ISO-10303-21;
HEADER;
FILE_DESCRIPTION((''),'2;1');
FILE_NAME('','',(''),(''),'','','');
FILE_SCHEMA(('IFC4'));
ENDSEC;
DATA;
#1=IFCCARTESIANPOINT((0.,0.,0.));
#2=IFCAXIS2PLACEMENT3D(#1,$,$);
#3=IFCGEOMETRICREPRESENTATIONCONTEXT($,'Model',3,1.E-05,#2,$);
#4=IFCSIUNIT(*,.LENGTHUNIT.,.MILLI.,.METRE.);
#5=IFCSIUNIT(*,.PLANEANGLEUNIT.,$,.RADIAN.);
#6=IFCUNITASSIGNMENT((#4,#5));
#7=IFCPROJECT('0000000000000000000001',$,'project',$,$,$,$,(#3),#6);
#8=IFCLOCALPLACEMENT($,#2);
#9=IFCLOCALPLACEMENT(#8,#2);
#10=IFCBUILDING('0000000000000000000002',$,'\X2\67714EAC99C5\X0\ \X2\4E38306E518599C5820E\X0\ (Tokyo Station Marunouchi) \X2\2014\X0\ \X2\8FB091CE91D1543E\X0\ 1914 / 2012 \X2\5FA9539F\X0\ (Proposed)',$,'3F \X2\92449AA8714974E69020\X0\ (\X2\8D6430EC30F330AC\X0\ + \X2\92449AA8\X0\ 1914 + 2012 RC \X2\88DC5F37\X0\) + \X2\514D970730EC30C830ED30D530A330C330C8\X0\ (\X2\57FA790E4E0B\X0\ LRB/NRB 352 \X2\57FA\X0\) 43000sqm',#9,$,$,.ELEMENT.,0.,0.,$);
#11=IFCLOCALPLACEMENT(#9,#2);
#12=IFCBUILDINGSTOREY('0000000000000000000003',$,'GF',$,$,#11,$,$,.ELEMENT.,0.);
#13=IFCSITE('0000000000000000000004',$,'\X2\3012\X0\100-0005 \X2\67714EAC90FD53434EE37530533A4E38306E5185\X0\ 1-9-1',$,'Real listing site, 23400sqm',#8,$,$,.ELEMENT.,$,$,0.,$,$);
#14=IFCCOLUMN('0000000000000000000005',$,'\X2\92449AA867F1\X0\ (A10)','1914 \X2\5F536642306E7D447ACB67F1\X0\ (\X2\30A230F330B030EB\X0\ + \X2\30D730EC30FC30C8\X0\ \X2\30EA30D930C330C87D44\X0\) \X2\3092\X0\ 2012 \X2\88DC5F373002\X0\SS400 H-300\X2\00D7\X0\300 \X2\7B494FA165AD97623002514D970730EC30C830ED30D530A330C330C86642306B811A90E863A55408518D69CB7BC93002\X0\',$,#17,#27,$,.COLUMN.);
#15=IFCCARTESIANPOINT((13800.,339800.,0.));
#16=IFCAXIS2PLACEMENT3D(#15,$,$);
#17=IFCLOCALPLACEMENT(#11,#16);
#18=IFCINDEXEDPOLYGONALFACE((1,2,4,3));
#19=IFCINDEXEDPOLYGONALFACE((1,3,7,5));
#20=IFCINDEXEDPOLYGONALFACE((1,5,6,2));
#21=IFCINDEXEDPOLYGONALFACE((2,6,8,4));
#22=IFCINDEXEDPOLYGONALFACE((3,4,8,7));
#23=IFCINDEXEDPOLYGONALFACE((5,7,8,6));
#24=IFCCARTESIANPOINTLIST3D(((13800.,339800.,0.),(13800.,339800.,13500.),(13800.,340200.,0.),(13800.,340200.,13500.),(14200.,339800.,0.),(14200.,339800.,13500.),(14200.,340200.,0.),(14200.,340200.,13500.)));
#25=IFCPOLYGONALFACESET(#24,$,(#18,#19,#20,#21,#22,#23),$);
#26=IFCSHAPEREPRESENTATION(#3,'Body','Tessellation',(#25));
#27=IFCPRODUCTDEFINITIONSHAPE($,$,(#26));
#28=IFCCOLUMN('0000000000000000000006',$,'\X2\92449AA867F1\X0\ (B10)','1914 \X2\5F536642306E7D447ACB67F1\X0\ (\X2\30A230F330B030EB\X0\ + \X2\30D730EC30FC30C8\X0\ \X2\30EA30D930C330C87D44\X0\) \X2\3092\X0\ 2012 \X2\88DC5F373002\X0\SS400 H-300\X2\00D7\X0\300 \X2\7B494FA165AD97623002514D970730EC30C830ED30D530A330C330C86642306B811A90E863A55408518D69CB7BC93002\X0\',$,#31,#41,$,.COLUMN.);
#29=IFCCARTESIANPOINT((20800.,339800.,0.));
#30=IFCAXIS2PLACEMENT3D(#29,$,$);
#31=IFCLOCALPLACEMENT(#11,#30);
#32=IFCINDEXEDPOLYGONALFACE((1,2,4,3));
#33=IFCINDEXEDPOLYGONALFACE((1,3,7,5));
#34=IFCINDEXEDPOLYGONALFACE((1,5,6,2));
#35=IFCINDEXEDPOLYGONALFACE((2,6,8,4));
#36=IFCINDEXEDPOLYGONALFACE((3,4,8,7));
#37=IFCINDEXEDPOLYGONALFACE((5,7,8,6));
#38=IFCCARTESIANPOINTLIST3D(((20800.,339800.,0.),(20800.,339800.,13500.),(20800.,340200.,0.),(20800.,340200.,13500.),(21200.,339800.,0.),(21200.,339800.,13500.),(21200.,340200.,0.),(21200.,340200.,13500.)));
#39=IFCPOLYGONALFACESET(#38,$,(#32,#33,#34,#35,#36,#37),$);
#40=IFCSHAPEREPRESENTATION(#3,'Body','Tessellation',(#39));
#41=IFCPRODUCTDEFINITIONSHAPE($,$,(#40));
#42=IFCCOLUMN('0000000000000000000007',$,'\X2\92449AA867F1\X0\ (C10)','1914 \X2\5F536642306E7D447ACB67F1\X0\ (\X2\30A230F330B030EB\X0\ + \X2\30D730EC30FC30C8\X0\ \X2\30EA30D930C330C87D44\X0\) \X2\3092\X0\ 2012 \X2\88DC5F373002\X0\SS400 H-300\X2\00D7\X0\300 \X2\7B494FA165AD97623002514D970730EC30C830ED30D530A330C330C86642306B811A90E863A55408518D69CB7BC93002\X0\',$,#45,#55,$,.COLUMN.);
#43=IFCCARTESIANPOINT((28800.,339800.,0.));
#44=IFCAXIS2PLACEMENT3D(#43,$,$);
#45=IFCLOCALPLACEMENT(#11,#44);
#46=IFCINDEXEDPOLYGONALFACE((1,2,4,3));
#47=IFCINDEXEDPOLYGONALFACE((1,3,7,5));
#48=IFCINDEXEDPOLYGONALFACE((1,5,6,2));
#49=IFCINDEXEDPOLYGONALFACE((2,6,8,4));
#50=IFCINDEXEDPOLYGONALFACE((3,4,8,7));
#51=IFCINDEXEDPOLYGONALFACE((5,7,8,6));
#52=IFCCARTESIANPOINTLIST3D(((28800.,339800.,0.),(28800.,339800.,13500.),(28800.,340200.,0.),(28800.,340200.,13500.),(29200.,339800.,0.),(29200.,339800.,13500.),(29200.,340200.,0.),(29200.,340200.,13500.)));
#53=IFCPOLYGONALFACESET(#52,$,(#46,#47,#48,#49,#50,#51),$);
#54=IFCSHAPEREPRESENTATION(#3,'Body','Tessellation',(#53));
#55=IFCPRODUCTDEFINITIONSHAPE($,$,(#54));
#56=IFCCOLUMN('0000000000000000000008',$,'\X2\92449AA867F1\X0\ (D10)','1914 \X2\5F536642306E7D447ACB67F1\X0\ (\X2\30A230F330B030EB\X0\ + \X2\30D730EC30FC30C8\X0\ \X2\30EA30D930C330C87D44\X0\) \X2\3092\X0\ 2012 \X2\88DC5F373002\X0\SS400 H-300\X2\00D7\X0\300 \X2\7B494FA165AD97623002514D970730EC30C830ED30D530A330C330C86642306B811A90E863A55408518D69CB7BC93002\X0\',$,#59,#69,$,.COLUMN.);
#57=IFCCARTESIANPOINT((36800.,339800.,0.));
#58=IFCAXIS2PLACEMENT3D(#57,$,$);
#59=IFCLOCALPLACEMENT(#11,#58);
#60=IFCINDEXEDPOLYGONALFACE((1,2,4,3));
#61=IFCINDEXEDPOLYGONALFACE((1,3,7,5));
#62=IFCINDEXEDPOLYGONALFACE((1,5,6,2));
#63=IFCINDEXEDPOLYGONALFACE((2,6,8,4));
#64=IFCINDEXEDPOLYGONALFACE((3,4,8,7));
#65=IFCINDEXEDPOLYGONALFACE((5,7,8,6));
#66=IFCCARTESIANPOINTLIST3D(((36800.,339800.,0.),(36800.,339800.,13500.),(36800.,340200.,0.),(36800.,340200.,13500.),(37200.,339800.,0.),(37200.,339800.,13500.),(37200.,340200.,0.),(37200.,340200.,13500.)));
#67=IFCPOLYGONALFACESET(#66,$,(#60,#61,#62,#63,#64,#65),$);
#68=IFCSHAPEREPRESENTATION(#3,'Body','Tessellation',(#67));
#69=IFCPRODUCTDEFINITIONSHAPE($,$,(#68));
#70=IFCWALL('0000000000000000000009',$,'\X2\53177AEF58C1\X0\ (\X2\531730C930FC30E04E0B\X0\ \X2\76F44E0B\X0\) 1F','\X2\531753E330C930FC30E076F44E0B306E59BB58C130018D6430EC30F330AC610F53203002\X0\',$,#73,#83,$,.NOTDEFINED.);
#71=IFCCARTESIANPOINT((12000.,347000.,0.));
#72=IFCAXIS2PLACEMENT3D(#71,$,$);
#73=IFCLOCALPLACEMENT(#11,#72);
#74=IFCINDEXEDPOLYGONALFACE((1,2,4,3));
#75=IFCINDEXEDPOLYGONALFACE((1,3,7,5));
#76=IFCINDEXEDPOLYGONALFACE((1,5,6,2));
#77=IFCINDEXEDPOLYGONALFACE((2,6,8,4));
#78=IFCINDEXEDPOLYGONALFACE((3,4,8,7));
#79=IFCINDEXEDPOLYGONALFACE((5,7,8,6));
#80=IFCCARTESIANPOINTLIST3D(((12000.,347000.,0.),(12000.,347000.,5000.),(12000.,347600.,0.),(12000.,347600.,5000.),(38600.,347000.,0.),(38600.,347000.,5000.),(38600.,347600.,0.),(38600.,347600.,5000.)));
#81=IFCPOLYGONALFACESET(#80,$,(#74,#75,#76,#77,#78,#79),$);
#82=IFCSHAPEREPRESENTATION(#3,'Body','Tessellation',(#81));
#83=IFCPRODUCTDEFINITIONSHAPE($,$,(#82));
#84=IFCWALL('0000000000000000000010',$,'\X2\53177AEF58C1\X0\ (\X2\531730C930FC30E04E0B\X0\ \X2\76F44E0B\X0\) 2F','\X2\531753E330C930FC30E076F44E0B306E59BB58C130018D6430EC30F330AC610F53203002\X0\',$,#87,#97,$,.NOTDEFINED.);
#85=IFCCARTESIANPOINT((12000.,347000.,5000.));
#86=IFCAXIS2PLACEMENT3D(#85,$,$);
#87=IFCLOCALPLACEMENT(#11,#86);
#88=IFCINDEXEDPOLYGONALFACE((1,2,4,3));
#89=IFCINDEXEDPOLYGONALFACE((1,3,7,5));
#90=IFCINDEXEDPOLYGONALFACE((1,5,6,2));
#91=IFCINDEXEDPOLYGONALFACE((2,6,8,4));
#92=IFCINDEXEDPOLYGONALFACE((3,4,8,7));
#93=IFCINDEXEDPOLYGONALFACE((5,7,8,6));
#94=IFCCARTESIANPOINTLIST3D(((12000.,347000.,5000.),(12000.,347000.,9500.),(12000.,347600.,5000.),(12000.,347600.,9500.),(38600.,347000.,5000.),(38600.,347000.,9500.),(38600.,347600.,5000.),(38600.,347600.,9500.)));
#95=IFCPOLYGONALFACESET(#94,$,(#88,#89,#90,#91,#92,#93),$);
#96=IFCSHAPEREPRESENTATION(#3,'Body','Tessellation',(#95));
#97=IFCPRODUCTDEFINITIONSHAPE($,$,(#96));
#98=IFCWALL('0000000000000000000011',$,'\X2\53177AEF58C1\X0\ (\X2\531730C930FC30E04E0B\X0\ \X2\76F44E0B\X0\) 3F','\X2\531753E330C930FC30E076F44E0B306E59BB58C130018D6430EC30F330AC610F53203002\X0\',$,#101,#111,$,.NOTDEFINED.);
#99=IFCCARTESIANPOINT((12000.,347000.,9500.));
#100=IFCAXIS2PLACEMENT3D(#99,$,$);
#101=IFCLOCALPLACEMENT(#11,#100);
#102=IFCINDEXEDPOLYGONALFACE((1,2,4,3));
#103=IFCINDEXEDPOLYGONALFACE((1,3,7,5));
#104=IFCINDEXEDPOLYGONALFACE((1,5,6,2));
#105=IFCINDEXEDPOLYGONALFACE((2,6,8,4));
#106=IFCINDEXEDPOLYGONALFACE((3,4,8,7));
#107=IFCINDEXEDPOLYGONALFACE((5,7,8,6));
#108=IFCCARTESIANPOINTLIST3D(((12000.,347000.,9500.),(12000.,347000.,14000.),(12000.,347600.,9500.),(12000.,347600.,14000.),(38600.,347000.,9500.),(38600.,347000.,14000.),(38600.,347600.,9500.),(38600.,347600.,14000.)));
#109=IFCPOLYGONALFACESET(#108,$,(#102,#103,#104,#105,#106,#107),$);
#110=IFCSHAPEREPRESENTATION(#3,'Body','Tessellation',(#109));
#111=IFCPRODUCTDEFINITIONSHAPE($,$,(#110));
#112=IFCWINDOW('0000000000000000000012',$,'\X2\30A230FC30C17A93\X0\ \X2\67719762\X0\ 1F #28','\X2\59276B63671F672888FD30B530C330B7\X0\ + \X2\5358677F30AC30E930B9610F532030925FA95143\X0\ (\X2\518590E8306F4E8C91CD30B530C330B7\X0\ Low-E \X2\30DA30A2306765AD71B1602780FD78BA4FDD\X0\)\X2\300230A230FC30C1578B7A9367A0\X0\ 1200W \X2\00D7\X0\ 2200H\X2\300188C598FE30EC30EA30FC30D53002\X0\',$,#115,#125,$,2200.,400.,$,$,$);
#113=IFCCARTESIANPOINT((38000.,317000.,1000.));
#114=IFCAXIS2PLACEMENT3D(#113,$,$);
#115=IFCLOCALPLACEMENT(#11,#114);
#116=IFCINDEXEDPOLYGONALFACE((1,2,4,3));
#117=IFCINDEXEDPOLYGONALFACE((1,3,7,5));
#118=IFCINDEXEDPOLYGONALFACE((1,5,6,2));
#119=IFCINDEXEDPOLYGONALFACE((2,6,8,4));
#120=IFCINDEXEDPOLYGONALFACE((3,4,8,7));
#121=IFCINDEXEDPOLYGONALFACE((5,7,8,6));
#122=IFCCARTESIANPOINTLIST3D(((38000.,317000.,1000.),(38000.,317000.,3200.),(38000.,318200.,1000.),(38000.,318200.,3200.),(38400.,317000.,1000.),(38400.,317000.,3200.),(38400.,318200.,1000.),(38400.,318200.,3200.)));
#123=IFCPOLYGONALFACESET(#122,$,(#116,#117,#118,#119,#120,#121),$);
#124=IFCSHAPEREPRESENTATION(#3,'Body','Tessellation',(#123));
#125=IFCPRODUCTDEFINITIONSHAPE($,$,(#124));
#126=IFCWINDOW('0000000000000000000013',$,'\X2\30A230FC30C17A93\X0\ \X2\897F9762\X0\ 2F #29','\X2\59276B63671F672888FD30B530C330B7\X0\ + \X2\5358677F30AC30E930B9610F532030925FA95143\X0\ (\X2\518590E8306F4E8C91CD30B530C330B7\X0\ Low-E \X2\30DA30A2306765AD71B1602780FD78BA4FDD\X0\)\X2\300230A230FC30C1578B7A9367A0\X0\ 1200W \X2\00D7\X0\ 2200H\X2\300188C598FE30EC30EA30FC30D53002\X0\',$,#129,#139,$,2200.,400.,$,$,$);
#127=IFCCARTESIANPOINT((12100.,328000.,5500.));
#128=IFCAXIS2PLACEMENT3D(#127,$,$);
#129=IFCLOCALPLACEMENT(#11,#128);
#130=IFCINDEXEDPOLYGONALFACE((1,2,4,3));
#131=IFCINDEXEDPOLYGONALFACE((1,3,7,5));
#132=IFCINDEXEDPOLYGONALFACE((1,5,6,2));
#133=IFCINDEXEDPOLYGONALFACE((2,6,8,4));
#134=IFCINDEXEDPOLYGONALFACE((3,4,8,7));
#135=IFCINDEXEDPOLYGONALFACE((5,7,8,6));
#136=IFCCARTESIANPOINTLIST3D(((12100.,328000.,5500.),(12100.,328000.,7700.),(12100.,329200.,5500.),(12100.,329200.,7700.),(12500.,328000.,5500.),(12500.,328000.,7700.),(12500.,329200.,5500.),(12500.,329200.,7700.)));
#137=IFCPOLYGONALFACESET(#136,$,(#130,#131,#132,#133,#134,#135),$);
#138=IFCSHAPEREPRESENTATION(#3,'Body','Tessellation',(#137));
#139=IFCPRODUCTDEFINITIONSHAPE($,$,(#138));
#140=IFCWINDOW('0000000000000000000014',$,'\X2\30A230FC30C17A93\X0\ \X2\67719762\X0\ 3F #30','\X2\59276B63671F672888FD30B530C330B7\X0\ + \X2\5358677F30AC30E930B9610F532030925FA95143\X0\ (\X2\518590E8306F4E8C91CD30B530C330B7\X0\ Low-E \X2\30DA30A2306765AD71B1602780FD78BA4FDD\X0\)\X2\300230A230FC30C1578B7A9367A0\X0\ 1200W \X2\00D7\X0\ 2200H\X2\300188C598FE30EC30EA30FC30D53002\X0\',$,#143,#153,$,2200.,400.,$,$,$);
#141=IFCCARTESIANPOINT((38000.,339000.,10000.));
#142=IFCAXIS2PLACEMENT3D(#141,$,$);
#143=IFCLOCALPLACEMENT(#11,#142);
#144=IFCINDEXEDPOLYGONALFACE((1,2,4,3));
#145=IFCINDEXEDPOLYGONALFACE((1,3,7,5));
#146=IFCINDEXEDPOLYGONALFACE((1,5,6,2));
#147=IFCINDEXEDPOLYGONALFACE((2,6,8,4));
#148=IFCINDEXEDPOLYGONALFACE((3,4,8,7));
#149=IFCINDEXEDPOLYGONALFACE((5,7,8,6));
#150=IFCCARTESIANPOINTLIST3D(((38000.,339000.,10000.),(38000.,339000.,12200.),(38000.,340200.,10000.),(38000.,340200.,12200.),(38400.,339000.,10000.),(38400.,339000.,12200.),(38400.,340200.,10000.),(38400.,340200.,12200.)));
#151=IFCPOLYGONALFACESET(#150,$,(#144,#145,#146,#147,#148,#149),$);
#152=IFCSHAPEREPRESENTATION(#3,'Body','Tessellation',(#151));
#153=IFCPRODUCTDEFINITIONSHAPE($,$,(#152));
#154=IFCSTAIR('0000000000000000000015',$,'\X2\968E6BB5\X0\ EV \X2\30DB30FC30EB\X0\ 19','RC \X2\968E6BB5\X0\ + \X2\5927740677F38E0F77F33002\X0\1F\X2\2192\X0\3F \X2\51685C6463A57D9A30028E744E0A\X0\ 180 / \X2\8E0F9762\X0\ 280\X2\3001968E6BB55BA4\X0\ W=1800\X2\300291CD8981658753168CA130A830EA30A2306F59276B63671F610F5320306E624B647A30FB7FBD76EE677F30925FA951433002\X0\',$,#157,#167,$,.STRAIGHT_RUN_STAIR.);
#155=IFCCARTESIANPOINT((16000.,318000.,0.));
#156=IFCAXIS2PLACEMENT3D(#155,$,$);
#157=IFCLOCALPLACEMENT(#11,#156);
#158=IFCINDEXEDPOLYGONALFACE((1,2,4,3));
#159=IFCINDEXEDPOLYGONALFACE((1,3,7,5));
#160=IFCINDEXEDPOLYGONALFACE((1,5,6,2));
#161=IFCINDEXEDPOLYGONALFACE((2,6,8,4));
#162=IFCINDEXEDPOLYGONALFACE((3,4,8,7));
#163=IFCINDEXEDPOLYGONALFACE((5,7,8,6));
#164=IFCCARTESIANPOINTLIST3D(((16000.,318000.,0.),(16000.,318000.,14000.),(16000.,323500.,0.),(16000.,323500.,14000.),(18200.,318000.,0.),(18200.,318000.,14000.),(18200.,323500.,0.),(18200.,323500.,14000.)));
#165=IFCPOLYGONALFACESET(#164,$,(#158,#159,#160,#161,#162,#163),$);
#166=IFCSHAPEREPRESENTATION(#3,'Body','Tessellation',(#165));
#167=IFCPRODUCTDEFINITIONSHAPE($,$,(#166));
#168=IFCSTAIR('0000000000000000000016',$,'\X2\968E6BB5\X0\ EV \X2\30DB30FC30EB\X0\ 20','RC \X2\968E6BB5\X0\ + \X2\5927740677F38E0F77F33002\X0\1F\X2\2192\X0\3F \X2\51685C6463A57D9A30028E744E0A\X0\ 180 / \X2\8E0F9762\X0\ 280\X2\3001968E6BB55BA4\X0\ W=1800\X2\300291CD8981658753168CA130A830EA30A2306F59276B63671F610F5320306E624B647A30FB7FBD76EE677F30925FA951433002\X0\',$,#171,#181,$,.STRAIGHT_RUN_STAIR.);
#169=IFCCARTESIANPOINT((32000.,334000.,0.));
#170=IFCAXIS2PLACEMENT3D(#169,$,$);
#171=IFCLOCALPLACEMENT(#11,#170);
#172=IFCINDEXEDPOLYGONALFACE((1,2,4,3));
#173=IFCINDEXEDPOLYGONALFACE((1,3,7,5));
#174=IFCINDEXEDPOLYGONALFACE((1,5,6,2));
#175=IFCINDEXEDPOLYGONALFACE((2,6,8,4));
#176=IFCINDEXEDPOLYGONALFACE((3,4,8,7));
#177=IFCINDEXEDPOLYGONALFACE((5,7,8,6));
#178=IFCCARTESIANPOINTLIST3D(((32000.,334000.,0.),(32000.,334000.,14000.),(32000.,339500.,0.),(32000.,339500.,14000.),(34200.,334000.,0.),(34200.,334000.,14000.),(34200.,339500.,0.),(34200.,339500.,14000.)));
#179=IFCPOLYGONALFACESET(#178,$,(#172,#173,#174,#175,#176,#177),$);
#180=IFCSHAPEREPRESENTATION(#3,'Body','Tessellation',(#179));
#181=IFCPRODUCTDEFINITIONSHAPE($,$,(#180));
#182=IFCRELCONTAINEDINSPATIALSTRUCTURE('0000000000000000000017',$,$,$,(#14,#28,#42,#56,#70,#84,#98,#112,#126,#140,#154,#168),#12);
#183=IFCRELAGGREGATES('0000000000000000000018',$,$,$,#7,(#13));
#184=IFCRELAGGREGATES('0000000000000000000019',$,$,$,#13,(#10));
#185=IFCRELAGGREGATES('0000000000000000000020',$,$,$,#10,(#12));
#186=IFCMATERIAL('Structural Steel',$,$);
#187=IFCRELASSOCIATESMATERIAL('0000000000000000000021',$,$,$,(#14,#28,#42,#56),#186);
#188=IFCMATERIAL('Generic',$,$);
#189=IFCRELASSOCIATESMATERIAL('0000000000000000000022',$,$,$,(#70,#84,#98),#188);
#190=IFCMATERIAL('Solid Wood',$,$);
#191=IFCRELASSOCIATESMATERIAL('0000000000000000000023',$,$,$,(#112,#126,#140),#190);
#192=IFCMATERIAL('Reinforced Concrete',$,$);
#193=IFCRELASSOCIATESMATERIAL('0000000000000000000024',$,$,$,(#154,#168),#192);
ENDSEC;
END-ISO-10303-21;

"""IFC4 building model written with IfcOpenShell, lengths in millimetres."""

from ifc_helpers import new_model, si_unit, frame, frame_2d, origin, place, context, project, spatial, rectangle, extrude, material, element, save


model = new_model("IFC4")

# Units and contexts
model_context = context("Model", 3, precision=1e-05, world=origin())
ifc_project = project(units=[si_unit("LENGTHUNIT", "METRE", prefix="MILLI"), si_unit("PLANEANGLEUNIT", "RADIAN")], contexts=[model_context])

# Site, building, storey
site_placement = place(None, origin())
site = spatial("IfcSite", under=ifc_project, at=site_placement, Name="〒100-0005 東京都千代田区丸の内 1-9-1", ObjectType="Real listing site, 23400sqm", CompositionType="ELEMENT", RefElevation=0.0)
building_placement = place(site_placement, origin())
building = spatial("IfcBuilding", under=site, at=building_placement, Name="東京駅 丸の内駅舎 (Tokyo Station Marunouchi) — 辰野金吾 1914 / 2012 復原 (Proposed)", ObjectType="3F 鉄骨煉瓦造 (赤レンガ + 鉄骨 1914 + 2012 RC 補強) + 免震レトロフィット (基礎下 LRB/NRB 352 基) 43000sqm", CompositionType="ELEMENT", ElevationOfRefHeight=0.0, ElevationOfTerrain=0.0)
storey_placement = place(building_placement, origin())
storey = spatial("IfcBuildingStorey", under=building, at=storey_placement, Name="GF", CompositionType="ELEMENT", Elevation=0.0)

# Columns
ifc_material_1 = material(Name="Structural Steel")
column_1_placement = place(storey_placement, frame((13800.0, 339800.0, 0.0)))
element("IfcColumn", 1, at=column_1_placement, inside=storey, material=ifc_material_1, Name="鉄骨柱 (A10)", Description="1914 当時の組立柱 (アングル + プレート リベット組) を 2012 補強。SS400 H-300×300 等価断面。免震レトロフィット時に脚部接合再構築。", PredefinedType="COLUMN", context=model_context, shape_type="SweptSolid", body=[
    extrude(rectangle(XDim=400.0, YDim=400.0, at=frame_2d((200.0, 200.0))), frame((13800.0, 339800.0, 0.0)), (0.0, 0.0, 1.0), 13500.0),
])
column_2_placement = place(storey_placement, frame((20800.0, 339800.0, 0.0)))
element("IfcColumn", 2, at=column_2_placement, inside=storey, material=ifc_material_1, Name="鉄骨柱 (B10)", Description="1914 当時の組立柱 (アングル + プレート リベット組) を 2012 補強。SS400 H-300×300 等価断面。免震レトロフィット時に脚部接合再構築。", PredefinedType="COLUMN", context=model_context, shape_type="SweptSolid", body=[
    extrude(rectangle(XDim=400.0, YDim=400.0, at=frame_2d((200.0, 200.0))), frame((20800.0, 339800.0, 0.0)), (0.0, 0.0, 1.0), 13500.0),
])
column_3_placement = place(storey_placement, frame((28800.0, 339800.0, 0.0)))
element("IfcColumn", 3, at=column_3_placement, inside=storey, material=ifc_material_1, Name="鉄骨柱 (C10)", Description="1914 当時の組立柱 (アングル + プレート リベット組) を 2012 補強。SS400 H-300×300 等価断面。免震レトロフィット時に脚部接合再構築。", PredefinedType="COLUMN", context=model_context, shape_type="SweptSolid", body=[
    extrude(rectangle(XDim=400.0, YDim=400.0, at=frame_2d((200.0, 200.0))), frame((28800.0, 339800.0, 0.0)), (0.0, 0.0, 1.0), 13500.0),
])
column_4_placement = place(storey_placement, frame((36800.0, 339800.0, 0.0)))
element("IfcColumn", 4, at=column_4_placement, inside=storey, material=ifc_material_1, Name="鉄骨柱 (D10)", Description="1914 当時の組立柱 (アングル + プレート リベット組) を 2012 補強。SS400 H-300×300 等価断面。免震レトロフィット時に脚部接合再構築。", PredefinedType="COLUMN", context=model_context, shape_type="SweptSolid", body=[
    extrude(rectangle(XDim=400.0, YDim=400.0, at=frame_2d((200.0, 200.0))), frame((36800.0, 339800.0, 0.0)), (0.0, 0.0, 1.0), 13500.0),
])

# Walls
ifc_material_2 = material(Name="Generic")
wall_1_placement = place(storey_placement, frame((12000.0, 347000.0, 0.0)))
element("IfcWall", 5, at=wall_1_placement, inside=storey, material=ifc_material_2, Name="北端壁 (北ドーム下 直下) 1F", Description="北口ドーム直下の妻壁、赤レンガ意匠。", PredefinedType="NOTDEFINED", context=model_context, shape_type="SweptSolid", body=[
    extrude(rectangle(XDim=26600.0, YDim=600.0, at=frame_2d((13300.0, 300.0))), frame((12000.0, 347000.0, 0.0)), (0.0, 0.0, 1.0), 5000.0),
])
wall_2_placement = place(storey_placement, frame((12000.0, 347000.0, 5000.0)))
element("IfcWall", 6, at=wall_2_placement, inside=storey, material=ifc_material_2, Name="北端壁 (北ドーム下 直下) 2F", Description="北口ドーム直下の妻壁、赤レンガ意匠。", PredefinedType="NOTDEFINED", context=model_context, shape_type="SweptSolid", body=[
    extrude(rectangle(XDim=26600.0, YDim=600.0, at=frame_2d((13300.0, 300.0))), frame((12000.0, 347000.0, 5000.0)), (0.0, 0.0, 1.0), 4500.0),
])
wall_3_placement = place(storey_placement, frame((12000.0, 347000.0, 9500.0)))
element("IfcWall", 7, at=wall_3_placement, inside=storey, material=ifc_material_2, Name="北端壁 (北ドーム下 直下) 3F", Description="北口ドーム直下の妻壁、赤レンガ意匠。", PredefinedType="NOTDEFINED", context=model_context, shape_type="SweptSolid", body=[
    extrude(rectangle(XDim=26600.0, YDim=600.0, at=frame_2d((13300.0, 300.0))), frame((12000.0, 347000.0, 9500.0)), (0.0, 0.0, 1.0), 4500.0),
])

# Windows
ifc_material_3 = material(Name="Solid Wood")
window_1_placement = place(storey_placement, frame((38000.0, 317000.0, 1000.0)))
element("IfcWindow", 8, at=window_1_placement, inside=storey, material=ifc_material_3, Name="アーチ窓 東面 1F #28", Description="大正期木製サッシ + 単板ガラス意匠を復元 (内部は二重サッシ Low-E ペアで断熱性能確保)。アーチ型窓枠 1200W × 2200H、装飾レリーフ。", OverallHeight=2200.0, OverallWidth=400.0, context=model_context, shape_type="SweptSolid", body=[
    extrude(rectangle(XDim=400.0, YDim=1200.0, at=frame_2d((200.0, 600.0))), frame((38000.0, 317000.0, 1000.0)), (0.0, 0.0, 1.0), 2200.0),
])
window_2_placement = place(storey_placement, frame((12100.0, 328000.0, 5500.0)))
element("IfcWindow", 9, at=window_2_placement, inside=storey, material=ifc_material_3, Name="アーチ窓 西面 2F #29", Description="大正期木製サッシ + 単板ガラス意匠を復元 (内部は二重サッシ Low-E ペアで断熱性能確保)。アーチ型窓枠 1200W × 2200H、装飾レリーフ。", OverallHeight=2200.0, OverallWidth=400.0, context=model_context, shape_type="SweptSolid", body=[
    extrude(rectangle(XDim=400.0, YDim=1200.0, at=frame_2d((200.0, 600.0))), frame((12100.0, 328000.0, 5500.0)), (0.0, 0.0, 1.0), 2200.0),
])
window_3_placement = place(storey_placement, frame((38000.0, 339000.0, 10000.0)))
element("IfcWindow", 10, at=window_3_placement, inside=storey, material=ifc_material_3, Name="アーチ窓 東面 3F #30", Description="大正期木製サッシ + 単板ガラス意匠を復元 (内部は二重サッシ Low-E ペアで断熱性能確保)。アーチ型窓枠 1200W × 2200H、装飾レリーフ。", OverallHeight=2200.0, OverallWidth=400.0, context=model_context, shape_type="SweptSolid", body=[
    extrude(rectangle(XDim=400.0, YDim=1200.0, at=frame_2d((200.0, 600.0))), frame((38000.0, 339000.0, 10000.0)), (0.0, 0.0, 1.0), 2200.0),
])

# Stairs
ifc_material_4 = material(Name="Reinforced Concrete")
stair_1_placement = place(storey_placement, frame((16000.0, 318000.0, 0.0)))
element("IfcStair", 11, at=stair_1_placement, inside=storey, material=ifc_material_4, Name="階段 EV ホール 19", Description="RC 階段 + 大理石踏石。1F→3F 全層接続。蹴上 180 / 踏面 280、階段室 W=1800。重要文化財エリアは大正期意匠の手摺・羽目板を復元。", PredefinedType="STRAIGHT_RUN_STAIR", context=model_context, shape_type="SweptSolid", body=[
    extrude(rectangle(XDim=2200.0, YDim=5500.0, at=frame_2d((1100.0, 2750.0))), frame((16000.0, 318000.0, 0.0)), (0.0, 0.0, 1.0), 14000.0),
])
stair_2_placement = place(storey_placement, frame((32000.0, 334000.0, 0.0)))
element("IfcStair", 12, at=stair_2_placement, inside=storey, material=ifc_material_4, Name="階段 EV ホール 20", Description="RC 階段 + 大理石踏石。1F→3F 全層接続。蹴上 180 / 踏面 280、階段室 W=1800。重要文化財エリアは大正期意匠の手摺・羽目板を復元。", PredefinedType="STRAIGHT_RUN_STAIR", context=model_context, shape_type="SweptSolid", body=[
    extrude(rectangle(XDim=2200.0, YDim=5500.0, at=frame_2d((1100.0, 2750.0))), frame((32000.0, 334000.0, 0.0)), (0.0, 0.0, 1.0), 14000.0),
])

save(model, "model.ifc")
